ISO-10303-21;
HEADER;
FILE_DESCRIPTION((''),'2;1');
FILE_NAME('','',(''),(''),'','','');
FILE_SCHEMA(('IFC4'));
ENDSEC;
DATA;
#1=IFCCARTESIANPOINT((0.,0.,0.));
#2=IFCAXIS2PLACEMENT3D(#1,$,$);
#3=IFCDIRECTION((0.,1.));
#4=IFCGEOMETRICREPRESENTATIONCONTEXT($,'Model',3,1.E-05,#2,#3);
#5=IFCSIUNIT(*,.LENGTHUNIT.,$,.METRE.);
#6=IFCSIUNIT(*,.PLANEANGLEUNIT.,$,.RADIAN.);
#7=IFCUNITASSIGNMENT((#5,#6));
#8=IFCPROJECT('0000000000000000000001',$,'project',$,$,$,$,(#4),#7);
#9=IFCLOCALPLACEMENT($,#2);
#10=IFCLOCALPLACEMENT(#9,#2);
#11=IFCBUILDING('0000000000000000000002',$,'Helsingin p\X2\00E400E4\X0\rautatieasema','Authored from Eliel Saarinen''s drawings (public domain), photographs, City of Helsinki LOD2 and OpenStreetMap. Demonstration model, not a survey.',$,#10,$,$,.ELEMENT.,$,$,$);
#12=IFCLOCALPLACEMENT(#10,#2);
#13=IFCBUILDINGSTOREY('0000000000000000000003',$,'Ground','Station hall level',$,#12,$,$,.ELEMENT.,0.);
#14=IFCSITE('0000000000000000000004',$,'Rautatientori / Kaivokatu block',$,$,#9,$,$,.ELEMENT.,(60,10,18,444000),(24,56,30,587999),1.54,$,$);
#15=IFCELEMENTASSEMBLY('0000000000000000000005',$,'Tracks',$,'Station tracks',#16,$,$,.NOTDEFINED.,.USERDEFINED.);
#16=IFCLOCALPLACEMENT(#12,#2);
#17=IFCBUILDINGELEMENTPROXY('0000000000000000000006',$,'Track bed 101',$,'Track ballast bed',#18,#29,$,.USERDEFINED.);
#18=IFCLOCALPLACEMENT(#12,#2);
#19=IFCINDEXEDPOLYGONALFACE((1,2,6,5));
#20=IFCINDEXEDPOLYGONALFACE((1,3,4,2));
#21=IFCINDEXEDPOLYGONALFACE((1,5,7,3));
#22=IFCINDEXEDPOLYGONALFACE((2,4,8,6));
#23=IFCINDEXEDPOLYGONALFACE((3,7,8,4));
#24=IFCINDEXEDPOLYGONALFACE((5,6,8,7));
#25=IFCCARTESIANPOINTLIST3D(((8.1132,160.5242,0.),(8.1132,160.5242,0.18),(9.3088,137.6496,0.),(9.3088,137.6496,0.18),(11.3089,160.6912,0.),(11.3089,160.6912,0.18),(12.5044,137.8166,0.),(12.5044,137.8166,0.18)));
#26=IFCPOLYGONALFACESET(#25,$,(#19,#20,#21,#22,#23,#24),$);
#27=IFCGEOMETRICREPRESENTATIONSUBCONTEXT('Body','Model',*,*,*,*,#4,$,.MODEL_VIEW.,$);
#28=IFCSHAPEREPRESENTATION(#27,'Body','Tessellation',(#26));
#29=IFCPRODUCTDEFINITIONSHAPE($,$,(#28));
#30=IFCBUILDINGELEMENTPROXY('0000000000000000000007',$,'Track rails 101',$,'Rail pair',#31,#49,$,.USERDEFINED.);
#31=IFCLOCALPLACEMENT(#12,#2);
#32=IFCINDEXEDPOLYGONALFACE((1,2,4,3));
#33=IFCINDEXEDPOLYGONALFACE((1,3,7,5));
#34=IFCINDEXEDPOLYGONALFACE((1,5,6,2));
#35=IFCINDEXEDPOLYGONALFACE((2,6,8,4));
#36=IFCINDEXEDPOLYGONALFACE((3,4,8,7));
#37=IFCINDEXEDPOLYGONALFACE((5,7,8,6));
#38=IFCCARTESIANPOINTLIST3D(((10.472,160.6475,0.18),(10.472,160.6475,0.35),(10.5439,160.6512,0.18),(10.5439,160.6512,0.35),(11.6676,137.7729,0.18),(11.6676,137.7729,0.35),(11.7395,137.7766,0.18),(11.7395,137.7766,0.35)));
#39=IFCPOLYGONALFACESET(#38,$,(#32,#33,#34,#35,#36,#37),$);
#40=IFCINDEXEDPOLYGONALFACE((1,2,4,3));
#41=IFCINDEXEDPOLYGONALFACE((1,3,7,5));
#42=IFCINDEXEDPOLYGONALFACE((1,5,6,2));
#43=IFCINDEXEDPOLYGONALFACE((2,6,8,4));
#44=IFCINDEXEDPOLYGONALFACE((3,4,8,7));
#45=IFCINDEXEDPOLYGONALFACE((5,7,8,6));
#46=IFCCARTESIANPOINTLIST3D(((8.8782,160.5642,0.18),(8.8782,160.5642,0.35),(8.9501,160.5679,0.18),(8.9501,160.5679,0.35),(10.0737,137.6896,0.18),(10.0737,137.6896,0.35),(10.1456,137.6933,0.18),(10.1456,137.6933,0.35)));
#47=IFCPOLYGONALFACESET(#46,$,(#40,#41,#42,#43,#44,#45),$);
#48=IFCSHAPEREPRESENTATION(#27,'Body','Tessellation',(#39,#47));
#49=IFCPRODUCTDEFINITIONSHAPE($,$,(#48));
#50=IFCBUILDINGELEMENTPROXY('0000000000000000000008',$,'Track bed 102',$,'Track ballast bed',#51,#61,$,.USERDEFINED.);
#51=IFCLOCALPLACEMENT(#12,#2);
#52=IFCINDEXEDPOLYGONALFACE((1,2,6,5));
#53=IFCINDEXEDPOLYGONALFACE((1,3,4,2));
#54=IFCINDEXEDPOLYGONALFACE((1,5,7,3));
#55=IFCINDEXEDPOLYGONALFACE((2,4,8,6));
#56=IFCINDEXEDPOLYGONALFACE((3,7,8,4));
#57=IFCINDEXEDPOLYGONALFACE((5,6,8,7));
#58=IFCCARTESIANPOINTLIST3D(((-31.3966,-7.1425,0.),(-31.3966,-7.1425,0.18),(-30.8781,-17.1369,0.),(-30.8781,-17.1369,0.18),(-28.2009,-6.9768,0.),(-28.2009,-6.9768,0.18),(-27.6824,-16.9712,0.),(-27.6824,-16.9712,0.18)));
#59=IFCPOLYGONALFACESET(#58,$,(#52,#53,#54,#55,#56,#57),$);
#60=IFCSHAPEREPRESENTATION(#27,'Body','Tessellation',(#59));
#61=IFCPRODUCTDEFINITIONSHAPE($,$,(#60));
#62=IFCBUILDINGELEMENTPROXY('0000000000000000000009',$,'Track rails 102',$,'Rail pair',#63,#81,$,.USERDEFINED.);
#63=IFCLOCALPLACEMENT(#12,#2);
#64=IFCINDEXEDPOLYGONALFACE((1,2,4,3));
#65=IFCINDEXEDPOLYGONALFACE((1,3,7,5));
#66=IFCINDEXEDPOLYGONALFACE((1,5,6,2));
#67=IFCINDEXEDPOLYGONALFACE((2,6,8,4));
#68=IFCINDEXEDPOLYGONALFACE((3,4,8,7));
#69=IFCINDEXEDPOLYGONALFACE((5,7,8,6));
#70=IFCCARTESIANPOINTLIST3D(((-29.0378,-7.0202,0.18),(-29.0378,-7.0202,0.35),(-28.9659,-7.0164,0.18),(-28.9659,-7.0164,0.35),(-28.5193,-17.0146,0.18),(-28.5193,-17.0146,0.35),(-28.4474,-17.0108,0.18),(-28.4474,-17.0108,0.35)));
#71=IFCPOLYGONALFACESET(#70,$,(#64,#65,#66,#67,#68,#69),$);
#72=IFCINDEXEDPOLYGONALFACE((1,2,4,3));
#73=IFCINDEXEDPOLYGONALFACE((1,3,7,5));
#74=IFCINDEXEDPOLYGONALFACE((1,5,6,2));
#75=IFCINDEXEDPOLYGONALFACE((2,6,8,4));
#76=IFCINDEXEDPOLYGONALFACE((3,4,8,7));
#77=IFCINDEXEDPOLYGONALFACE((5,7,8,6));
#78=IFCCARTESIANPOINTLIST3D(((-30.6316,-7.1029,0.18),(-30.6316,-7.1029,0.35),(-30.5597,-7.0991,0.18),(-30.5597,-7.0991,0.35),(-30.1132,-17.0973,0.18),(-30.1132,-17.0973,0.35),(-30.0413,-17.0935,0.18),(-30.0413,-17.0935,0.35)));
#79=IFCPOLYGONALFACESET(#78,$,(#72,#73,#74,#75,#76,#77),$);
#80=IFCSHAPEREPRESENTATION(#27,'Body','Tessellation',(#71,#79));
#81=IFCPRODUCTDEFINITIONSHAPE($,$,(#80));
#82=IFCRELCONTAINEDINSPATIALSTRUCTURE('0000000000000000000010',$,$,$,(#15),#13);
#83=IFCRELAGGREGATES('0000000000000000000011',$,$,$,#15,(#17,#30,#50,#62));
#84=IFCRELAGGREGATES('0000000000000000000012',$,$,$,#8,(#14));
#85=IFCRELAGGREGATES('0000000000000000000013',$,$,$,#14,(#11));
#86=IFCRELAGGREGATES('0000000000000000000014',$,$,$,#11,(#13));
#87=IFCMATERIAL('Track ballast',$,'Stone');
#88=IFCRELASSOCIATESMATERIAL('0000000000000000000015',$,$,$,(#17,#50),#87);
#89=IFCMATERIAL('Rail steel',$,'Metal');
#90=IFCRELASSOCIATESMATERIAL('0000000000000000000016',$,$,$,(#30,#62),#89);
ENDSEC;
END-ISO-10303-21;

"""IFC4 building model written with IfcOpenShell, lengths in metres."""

from ifc_helpers import new_model, si_unit, direction, frame, origin, place, context, subcontext, project, spatial, polyline, outline, extrude, material, element, aggregate, save


model = new_model("IFC4")

# Units and contexts
model_context = context("Model", 3, precision=1e-05, world=origin(), true_north=direction((0.0, 1.0)))
body_context = subcontext(model_context, "Body", "Model", "MODEL_VIEW")
ifc_project = project(units=[si_unit("LENGTHUNIT", "METRE"), si_unit("PLANEANGLEUNIT", "RADIAN")], contexts=[model_context])

# Site, building, storey
site_placement = place(None, origin())
site = spatial("IfcSite", under=ifc_project, at=site_placement, Name="Rautatientori / Kaivokatu block", CompositionType="ELEMENT", RefLatitude=(60, 10, 18, 444000), RefLongitude=(24, 56, 30, 587999), RefElevation=1.54)
building_placement = place(site_placement, origin())
building = spatial("IfcBuilding", under=site, at=building_placement, Name="Helsingin päärautatieasema", Description="Authored from Eliel Saarinen's drawings (public domain), photographs, City of Helsinki LOD2 and OpenStreetMap. Demonstration model, not a survey.", CompositionType="ELEMENT")
storey_placement = place(building_placement, origin())
storey = spatial("IfcBuildingStorey", under=building, at=storey_placement, Name="Ground", Description="Station hall level", CompositionType="ELEMENT", Elevation=0.0)

# Element assembly, building element proxies
assembly_placement = place(building_placement, origin())
assembly = element("IfcElementAssembly", 1, at=assembly_placement, inside=storey, Name="Tracks", ObjectType="Station tracks", AssemblyPlace="NOTDEFINED", PredefinedType="USERDEFINED")
ifc_material_1 = material(Name="Track ballast", Category="Stone")
ifc_material_2 = material(Name="Rail steel", Category="Metal")
proxy_1_placement = place(building_placement, origin())
proxy_1 = element("IfcBuildingElementProxy", 2, at=proxy_1_placement, material=ifc_material_1, Name="Track bed 101", ObjectType="Track ballast bed", PredefinedType="USERDEFINED", context=body_context, shape_type="SweptSolid", body=[
    extrude(outline(polyline([(8.1132, 160.5242), (11.3089, 160.6912), (12.5044, 137.8166), (9.3088, 137.6496), (8.1132, 160.5242)])), origin(), (0.0, 0.0, 1.0), 0.18),
])
proxy_2_placement = place(building_placement, origin())
proxy_2 = element("IfcBuildingElementProxy", 3, at=proxy_2_placement, material=ifc_material_2, Name="Track rails 101", ObjectType="Rail pair", PredefinedType="USERDEFINED", context=body_context, shape_type="SweptSolid", body=[
    extrude(outline(polyline([(10.472, 160.6475), (10.5439, 160.6512), (11.7395, 137.7766), (11.6676, 137.7729), (10.472, 160.6475)])), frame((0.0, 0.0, 0.18)), (0.0, 0.0, 1.0), 0.17),
    extrude(outline(polyline([(8.8782, 160.5642), (8.9501, 160.5679), (10.1456, 137.6933), (10.0737, 137.6896), (8.8782, 160.5642)])), frame((0.0, 0.0, 0.18)), (0.0, 0.0, 1.0), 0.17),
])
proxy_3_placement = place(building_placement, origin())
proxy_3 = element("IfcBuildingElementProxy", 4, at=proxy_3_placement, material=ifc_material_1, Name="Track bed 102", ObjectType="Track ballast bed", PredefinedType="USERDEFINED", context=body_context, shape_type="SweptSolid", body=[
    extrude(outline(polyline([(-31.3966, -7.1425), (-28.2009, -6.9768), (-27.6824, -16.9712), (-30.8781, -17.1369), (-31.3966, -7.1425)])), origin(), (0.0, 0.0, 1.0), 0.18),
])
proxy_4_placement = place(building_placement, origin())
proxy_4 = element("IfcBuildingElementProxy", 5, at=proxy_4_placement, material=ifc_material_2, Name="Track rails 102", ObjectType="Rail pair", PredefinedType="USERDEFINED", context=body_context, shape_type="SweptSolid", body=[
    extrude(outline(polyline([(-29.0378, -7.0202), (-28.9659, -7.0164), (-28.4474, -17.0108), (-28.5193, -17.0146), (-29.0378, -7.0202)])), frame((0.0, 0.0, 0.18)), (0.0, 0.0, 1.0), 0.17),
    extrude(outline(polyline([(-30.6316, -7.1029), (-30.5597, -7.0991), (-30.0413, -17.0935), (-30.1132, -17.0973), (-30.6316, -7.1029)])), frame((0.0, 0.0, 0.18)), (0.0, 0.0, 1.0), 0.17),
])
aggregate(assembly, [proxy_1, proxy_2, proxy_3, proxy_4])

save(model, "model.ifc")
